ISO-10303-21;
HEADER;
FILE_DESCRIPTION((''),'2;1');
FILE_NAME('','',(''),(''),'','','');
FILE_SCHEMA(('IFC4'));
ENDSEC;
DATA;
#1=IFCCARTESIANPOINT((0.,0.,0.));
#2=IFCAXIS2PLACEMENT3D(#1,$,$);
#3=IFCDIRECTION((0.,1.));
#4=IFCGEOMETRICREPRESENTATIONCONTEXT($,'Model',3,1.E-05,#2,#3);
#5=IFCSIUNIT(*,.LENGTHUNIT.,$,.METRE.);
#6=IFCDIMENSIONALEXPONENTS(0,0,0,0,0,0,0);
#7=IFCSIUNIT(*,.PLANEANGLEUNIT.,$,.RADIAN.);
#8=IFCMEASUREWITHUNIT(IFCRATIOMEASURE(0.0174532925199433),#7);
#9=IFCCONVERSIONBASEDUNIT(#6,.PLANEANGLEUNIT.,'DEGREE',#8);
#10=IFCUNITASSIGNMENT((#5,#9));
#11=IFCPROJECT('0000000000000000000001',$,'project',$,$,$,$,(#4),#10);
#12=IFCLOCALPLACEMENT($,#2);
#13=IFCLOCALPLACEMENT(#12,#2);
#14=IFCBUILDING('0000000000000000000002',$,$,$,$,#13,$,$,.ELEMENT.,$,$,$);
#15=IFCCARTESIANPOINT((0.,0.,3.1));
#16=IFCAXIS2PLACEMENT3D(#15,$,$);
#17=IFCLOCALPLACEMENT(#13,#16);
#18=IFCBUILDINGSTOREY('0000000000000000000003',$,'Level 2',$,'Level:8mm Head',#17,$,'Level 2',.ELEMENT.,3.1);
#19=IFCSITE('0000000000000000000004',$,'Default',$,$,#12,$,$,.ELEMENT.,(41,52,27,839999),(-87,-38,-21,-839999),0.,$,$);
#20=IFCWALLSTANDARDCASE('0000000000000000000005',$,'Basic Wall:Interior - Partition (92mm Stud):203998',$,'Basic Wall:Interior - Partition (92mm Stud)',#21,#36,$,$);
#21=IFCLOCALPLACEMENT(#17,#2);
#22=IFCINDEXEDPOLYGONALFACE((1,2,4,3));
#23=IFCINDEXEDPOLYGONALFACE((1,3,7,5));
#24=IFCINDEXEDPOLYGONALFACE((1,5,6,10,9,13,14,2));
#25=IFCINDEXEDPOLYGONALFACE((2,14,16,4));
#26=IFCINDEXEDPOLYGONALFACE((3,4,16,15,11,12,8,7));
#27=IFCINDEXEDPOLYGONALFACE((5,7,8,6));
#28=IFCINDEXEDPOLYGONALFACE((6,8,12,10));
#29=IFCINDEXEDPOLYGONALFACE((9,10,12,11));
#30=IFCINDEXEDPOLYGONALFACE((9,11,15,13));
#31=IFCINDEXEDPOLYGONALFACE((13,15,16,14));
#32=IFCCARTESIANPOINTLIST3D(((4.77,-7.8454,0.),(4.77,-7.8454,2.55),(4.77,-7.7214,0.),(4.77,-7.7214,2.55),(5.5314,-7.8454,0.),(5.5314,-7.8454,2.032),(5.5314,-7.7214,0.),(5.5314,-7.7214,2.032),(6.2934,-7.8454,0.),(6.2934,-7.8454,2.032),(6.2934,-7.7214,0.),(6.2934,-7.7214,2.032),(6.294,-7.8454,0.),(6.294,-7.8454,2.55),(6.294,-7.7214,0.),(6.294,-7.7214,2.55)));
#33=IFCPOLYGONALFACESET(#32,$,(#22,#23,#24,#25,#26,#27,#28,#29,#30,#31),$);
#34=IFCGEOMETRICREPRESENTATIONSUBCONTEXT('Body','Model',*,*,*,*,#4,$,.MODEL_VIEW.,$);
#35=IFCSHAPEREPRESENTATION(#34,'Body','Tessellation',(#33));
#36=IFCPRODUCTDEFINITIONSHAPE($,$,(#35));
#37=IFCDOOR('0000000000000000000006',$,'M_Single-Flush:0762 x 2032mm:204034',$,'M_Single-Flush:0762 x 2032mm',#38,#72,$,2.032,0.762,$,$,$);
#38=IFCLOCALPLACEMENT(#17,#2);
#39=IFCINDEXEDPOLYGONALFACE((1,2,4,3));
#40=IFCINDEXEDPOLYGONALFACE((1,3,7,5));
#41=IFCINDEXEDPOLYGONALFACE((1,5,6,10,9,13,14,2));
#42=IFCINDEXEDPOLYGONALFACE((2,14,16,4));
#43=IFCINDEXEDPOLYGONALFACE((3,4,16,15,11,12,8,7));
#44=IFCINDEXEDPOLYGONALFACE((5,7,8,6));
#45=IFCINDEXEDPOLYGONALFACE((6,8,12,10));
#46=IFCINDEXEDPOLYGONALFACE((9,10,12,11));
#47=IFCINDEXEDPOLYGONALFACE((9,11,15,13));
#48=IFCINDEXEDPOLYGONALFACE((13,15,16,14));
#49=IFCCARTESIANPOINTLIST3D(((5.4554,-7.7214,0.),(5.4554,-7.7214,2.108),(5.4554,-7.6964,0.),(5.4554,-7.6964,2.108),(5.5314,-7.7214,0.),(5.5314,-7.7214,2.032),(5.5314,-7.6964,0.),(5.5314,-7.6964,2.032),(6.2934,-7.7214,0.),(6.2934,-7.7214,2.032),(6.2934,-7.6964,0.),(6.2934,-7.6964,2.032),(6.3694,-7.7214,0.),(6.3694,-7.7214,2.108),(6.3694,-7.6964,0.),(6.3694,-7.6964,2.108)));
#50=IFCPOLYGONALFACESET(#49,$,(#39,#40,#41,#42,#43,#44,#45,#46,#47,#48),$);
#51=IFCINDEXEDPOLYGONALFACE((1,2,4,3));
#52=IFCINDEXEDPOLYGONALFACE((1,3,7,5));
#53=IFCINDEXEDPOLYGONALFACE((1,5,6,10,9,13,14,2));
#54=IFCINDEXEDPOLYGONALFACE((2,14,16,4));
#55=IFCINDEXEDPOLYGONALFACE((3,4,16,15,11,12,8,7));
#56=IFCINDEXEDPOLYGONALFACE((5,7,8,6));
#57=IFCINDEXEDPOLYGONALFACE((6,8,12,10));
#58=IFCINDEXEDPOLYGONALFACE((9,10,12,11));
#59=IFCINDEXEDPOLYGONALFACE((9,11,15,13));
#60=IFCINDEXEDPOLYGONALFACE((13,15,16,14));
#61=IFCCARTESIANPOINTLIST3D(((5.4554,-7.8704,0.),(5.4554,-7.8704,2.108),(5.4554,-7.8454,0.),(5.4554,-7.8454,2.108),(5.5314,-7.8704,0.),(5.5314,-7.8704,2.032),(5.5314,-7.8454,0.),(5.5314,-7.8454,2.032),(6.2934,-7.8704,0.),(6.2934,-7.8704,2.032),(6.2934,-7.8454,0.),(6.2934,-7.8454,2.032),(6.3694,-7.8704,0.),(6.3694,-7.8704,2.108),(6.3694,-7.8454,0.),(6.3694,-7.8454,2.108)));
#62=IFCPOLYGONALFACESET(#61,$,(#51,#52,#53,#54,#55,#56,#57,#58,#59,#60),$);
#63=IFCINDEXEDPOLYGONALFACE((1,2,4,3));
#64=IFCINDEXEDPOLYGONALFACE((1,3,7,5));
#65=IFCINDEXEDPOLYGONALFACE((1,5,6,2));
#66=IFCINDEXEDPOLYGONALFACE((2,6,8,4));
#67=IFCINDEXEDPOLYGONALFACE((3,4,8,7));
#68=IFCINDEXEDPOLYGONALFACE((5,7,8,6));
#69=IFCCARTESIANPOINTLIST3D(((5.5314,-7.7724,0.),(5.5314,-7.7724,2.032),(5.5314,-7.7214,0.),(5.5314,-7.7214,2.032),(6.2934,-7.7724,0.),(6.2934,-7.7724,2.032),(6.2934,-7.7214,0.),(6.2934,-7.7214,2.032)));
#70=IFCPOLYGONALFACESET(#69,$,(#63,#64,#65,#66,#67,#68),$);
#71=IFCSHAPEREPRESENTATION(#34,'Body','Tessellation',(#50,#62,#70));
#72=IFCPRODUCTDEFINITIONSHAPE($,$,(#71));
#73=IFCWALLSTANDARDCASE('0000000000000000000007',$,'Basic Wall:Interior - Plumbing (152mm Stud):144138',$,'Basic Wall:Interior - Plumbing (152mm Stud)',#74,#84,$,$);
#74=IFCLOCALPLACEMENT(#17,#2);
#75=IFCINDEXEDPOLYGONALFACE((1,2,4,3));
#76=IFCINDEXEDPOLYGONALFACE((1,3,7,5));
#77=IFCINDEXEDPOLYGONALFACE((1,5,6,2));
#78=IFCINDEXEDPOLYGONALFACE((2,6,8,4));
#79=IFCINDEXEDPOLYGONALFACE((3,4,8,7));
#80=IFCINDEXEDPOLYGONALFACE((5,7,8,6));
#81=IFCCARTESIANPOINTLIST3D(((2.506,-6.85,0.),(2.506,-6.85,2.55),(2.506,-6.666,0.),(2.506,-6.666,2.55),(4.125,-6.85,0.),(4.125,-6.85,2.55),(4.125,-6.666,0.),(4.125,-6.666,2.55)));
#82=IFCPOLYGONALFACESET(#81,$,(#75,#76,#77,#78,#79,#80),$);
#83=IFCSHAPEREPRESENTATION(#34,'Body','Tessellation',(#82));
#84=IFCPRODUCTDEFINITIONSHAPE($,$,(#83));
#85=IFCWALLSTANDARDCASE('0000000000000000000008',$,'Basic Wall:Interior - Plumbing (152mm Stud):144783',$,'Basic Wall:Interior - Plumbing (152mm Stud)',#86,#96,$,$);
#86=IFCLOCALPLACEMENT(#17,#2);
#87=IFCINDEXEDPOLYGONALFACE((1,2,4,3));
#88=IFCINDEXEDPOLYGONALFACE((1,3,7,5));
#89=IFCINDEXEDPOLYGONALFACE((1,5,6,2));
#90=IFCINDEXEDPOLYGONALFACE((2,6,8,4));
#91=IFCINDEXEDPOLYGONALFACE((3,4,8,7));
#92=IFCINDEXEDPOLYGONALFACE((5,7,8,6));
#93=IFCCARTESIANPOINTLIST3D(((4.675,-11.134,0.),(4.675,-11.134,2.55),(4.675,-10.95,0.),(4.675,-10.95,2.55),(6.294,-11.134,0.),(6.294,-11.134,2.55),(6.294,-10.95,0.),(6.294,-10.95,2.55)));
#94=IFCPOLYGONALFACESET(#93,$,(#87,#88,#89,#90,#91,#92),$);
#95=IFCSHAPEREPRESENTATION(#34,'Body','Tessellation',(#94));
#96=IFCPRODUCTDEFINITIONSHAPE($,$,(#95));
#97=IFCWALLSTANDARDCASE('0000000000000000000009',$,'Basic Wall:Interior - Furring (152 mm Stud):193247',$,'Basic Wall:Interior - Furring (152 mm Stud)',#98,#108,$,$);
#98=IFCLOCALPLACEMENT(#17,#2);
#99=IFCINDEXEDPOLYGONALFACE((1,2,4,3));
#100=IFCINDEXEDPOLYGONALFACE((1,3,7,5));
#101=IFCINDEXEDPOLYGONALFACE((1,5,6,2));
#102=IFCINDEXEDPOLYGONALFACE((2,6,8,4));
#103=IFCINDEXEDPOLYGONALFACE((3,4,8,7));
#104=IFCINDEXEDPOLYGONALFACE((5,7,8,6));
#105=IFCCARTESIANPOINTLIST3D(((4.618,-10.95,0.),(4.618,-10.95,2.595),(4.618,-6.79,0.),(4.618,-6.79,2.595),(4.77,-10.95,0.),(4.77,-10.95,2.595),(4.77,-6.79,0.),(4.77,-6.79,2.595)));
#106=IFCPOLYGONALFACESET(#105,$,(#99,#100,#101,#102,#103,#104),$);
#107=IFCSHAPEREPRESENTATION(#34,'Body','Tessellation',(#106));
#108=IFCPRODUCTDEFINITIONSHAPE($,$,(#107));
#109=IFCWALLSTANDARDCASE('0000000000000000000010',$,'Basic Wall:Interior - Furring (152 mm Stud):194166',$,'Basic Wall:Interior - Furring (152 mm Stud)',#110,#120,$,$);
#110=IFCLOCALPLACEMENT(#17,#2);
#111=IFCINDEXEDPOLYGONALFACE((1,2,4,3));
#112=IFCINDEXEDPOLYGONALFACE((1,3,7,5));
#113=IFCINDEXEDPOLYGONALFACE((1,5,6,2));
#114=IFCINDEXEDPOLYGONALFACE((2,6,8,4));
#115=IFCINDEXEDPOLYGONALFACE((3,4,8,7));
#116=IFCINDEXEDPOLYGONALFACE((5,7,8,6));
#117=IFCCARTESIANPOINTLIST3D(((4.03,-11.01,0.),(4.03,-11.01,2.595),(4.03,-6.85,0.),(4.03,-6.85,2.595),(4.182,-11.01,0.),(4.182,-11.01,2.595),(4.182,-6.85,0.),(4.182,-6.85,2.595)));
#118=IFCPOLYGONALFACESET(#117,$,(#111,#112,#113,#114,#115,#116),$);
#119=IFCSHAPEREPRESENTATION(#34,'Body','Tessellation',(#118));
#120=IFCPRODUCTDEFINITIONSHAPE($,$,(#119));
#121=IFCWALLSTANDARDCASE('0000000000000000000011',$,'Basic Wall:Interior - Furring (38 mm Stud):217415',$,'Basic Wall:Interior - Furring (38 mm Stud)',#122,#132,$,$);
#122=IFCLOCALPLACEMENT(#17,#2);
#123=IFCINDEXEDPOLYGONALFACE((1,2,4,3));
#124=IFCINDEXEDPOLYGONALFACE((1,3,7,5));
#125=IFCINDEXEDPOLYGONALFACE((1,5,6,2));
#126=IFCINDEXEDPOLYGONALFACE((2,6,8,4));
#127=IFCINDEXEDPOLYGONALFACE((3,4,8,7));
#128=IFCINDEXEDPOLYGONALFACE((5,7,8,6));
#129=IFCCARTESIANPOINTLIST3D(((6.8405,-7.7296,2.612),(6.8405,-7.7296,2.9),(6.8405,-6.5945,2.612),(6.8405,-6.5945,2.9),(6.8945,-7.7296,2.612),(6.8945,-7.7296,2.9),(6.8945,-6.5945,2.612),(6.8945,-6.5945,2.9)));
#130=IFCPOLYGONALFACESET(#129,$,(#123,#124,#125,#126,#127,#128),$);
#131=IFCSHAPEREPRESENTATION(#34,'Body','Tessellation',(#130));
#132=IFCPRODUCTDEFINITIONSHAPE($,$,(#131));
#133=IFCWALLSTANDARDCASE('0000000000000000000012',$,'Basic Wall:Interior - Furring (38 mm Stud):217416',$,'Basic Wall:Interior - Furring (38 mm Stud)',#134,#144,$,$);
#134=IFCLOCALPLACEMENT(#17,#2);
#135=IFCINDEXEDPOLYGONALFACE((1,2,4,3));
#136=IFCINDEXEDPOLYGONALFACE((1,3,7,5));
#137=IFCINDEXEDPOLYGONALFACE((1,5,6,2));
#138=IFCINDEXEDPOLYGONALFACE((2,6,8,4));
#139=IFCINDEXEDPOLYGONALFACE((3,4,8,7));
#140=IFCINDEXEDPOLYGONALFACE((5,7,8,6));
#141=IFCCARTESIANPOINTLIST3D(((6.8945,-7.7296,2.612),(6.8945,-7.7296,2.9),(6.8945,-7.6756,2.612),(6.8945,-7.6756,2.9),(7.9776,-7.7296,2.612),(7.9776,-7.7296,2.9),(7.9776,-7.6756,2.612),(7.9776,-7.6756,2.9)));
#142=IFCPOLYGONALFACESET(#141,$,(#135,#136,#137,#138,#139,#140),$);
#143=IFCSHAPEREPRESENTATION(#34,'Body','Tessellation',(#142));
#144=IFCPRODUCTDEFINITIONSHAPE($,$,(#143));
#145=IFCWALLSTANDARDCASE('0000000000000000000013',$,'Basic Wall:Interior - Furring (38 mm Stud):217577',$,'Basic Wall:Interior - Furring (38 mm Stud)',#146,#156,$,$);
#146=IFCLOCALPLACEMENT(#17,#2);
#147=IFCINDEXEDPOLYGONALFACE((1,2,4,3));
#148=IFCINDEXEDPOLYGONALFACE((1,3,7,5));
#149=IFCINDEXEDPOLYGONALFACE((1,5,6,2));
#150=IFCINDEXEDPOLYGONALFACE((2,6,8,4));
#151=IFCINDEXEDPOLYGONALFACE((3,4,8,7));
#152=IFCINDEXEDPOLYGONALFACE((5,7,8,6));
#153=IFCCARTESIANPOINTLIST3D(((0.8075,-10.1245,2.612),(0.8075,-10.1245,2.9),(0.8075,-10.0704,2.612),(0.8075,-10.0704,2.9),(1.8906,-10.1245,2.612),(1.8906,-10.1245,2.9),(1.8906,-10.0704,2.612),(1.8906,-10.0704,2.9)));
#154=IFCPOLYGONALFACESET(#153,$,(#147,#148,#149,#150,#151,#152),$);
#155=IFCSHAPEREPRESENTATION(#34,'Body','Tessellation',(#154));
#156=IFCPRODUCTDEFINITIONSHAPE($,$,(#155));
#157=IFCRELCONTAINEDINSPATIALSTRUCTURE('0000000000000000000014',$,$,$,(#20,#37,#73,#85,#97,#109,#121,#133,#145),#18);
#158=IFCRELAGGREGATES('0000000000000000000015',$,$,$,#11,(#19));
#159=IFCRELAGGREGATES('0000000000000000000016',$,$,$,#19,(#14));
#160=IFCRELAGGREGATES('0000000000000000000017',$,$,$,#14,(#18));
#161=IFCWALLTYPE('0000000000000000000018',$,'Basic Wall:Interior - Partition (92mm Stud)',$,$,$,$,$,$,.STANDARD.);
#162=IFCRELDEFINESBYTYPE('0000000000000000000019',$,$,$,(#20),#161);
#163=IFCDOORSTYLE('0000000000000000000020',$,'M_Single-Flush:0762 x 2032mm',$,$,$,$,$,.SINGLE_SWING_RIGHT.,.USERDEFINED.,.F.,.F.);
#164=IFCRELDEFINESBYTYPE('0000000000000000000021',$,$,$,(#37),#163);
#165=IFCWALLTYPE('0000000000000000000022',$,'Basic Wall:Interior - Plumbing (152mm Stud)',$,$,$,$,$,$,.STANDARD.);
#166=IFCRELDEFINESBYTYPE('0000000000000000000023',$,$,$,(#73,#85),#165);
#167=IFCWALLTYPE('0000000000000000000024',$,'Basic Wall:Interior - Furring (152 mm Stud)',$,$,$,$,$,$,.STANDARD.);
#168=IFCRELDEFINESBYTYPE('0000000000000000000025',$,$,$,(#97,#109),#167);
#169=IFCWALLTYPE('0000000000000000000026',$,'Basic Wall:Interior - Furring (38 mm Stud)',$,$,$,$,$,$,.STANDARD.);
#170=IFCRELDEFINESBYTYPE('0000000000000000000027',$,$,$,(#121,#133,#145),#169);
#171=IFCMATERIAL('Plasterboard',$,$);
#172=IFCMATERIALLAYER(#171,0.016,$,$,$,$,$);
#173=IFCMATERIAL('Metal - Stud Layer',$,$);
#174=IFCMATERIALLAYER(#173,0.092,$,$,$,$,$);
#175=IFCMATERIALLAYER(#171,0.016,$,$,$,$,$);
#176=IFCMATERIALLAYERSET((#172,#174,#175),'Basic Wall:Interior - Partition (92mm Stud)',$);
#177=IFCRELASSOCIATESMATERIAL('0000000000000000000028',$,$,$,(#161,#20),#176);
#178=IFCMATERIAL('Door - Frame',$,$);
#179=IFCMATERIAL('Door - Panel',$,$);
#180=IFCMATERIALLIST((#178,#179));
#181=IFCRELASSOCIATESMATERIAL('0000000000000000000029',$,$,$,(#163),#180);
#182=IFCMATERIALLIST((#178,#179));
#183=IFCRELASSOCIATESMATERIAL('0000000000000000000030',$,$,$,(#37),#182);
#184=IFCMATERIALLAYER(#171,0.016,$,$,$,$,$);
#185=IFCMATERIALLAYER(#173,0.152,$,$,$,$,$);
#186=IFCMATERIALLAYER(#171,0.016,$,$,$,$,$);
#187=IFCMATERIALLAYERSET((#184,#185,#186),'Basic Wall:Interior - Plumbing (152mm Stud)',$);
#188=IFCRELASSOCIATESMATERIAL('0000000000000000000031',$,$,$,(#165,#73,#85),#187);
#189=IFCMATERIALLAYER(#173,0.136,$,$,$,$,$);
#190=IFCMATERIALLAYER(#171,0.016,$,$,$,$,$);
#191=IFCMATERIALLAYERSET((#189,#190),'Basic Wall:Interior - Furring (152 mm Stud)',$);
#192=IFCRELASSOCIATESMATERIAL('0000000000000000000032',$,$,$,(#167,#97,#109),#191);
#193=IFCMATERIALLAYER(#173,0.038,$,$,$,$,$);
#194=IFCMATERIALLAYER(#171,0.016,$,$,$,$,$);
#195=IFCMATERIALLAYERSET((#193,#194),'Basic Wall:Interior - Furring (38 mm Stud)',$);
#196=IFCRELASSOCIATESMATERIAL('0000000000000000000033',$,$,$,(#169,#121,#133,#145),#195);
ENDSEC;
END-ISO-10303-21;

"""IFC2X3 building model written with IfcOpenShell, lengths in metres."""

from ifc_helpers import new_model, entity, si_unit, converted_unit, direction, frame, frame_2d, origin, origin_2d_with_axis, place, context, subcontext, project, spatial, polyline, rectangle, outline, extrude, source, transform, mapped, material, material_list, layer, layer_set, layer_usage, type_object, type_shapes, element, fill, save


model = new_model("IFC2X3")

# Units and contexts
model_context = context("Model", 3, precision=1e-05, world=origin(), true_north=direction((0.0, 1.0)))
body_context = subcontext(model_context, "Body", "Model", "MODEL_VIEW")
ifc_project = project(units=[si_unit("LENGTHUNIT", "METRE"), converted_unit("PLANEANGLEUNIT", "DEGREE", entity("IfcRatioMeasure", 0.0174532925199433), si_unit("PLANEANGLEUNIT", "RADIAN"), dimensions=[0, 0, 0, 0, 0, 0, 0])], contexts=[model_context])

# Site, building, storey
site_placement = place(None, origin())
site = spatial("IfcSite", under=ifc_project, at=site_placement, Name="Default", CompositionType="ELEMENT", RefLatitude=(41, 52, 27, 839999), RefLongitude=(-87, -38, -21, -839999), RefElevation=0.0)
building_placement = place(site_placement, origin())
building = spatial("IfcBuilding", under=site, at=building_placement, CompositionType="ELEMENT")
storey_placement = place(building_placement, frame((0.0, 0.0, 3.1)))
storey = spatial("IfcBuildingStorey", under=building, at=storey_placement, Name="Level 2", ObjectType="Level:8mm Head", LongName="Level 2", CompositionType="ELEMENT", Elevation=3.1)

# Shared definitions
ifc_material_1 = material(Name="Plasterboard")
ifc_layer_1 = layer(ifc_material_1, 0.016)
ifc_material_2 = material(Name="Metal - Stud Layer")
ifc_layer_2 = layer(ifc_material_2, 0.092)
ifc_layer_3 = layer(ifc_material_1, 0.016)
ifc_layer_set_1 = layer_set([ifc_layer_1, ifc_layer_2, ifc_layer_3], Name="Basic Wall:Interior - Partition (92mm Stud)")
wall_type_1 = type_object("IfcWallType", Name="Basic Wall:Interior - Partition (92mm Stud)", PredefinedType="STANDARD", material=ifc_layer_set_1)

# Wall, opening, door
ifc_material_3 = material(Name="Door - Frame")
ifc_material_4 = material(Name="Door - Panel")
ifc_material_list_1 = material_list([ifc_material_3, ifc_material_4])
door_style = type_object("IfcDoorStyle", Name="M_Single-Flush:0762 x 2032mm", ConstructionType="USERDEFINED", OperationType="SINGLE_SWING_RIGHT", ParameterTakesPrecedence=False, Sizeable=False, material=ifc_material_list_1)
shared_shape_1 = source(origin(), body_context, "Body", "SweptSolid", [
    extrude(outline(polyline([(-0.457, -1.073), (0.457, -1.073), (0.457, 1.035), (0.381, 1.035), (0.381, -0.997), (-0.381, -0.997), (-0.381, 1.035), (-0.457, 1.035), (-0.457, -1.073)])), frame((0.381, 0.124, 1.035), z_axis=(0.0, 1.0, 0.0), x_axis=(1.0, 0.0, 0.0)), (0.0, 0.0, 1.0), 0.025),
    extrude(outline(polyline([(-1.073, -0.457), (1.035, -0.457), (1.035, -0.381), (-0.997, -0.381), (-0.997, 0.381), (1.035, 0.381), (1.035, 0.457), (-1.073, 0.457), (-1.073, -0.457)])), frame((0.381, -0.025, 1.035), z_axis=(0.0, 1.0, 0.0), x_axis=(0.0, 0.0, -1.0)), (0.0, 0.0, 1.0), 0.025),
    extrude(rectangle(XDim=0.051, YDim=0.762, at=origin_2d_with_axis()), frame((0.381, 0.0985, 0.0), z_axis=(0.0, 0.0, 1.0), x_axis=(0.0, 1.0, 0.0)), (0.0, 0.0, 1.0), 2.032),
])
type_shapes(door_style, [shared_shape_1])
ifc_layer_usage_1 = layer_usage(ifc_layer_set_1, "AXIS2", "POSITIVE", -0.062)
wall_1_placement = place(storey_placement, frame((4.77, -7.7834, 0.0)))
wall_1 = element("IfcWallStandardCase", 1, at=wall_1_placement, inside=storey, type_object=wall_type_1, material=ifc_layer_usage_1, Name="Basic Wall:Interior - Partition (92mm Stud):203998", ObjectType="Basic Wall:Interior - Partition (92mm Stud)", context=body_context, shape_type="SweptSolid", body=[
    extrude(rectangle(XDim=1.524, YDim=0.124, at=frame_2d((0.762, 0.0), x_axis=(-1.0, 0.0))), origin(), (0.0, 0.0, 1.0), 2.55),
])
opening_1_placement = place(wall_1_placement, frame((0.7614, -0.062, 0.0)))
opening_1 = element("IfcOpeningElement", 2, at=opening_1_placement, cuts=wall_1, ObjectType="Opening", context=body_context, shape_type="SweptSolid", body=[
    extrude(rectangle(XDim=0.762, YDim=2.032, at=frame_2d((1.016, 0.381), x_axis=(0.0, 1.0))), frame((0.0, 0.0, 0.0), z_axis=(0.0, 1.0, 0.0), x_axis=(0.0, 0.0, 1.0)), (0.0, 0.0, 1.0), 0.124),
])
ifc_material_list_2 = material_list([ifc_material_3, ifc_material_4])
door_1_placement = place(opening_1_placement, origin())
door_1 = element("IfcDoor", 3, at=door_1_placement, inside=storey, type_object=door_style, material=ifc_material_list_2, Name="M_Single-Flush:0762 x 2032mm:204034", ObjectType="M_Single-Flush:0762 x 2032mm", OverallHeight=2.032, OverallWidth=0.762, context=body_context, shape_type="MappedRepresentation", body=[
    mapped(shared_shape_1, transform((0.0, 0.0, 0.0), scale=1.0)),
])
fill(opening_1, door_1)

# Walls
ifc_layer_4 = layer(ifc_material_1, 0.016)
ifc_layer_5 = layer(ifc_material_2, 0.152)
ifc_layer_6 = layer(ifc_material_1, 0.016)
ifc_layer_set_2 = layer_set([ifc_layer_4, ifc_layer_5, ifc_layer_6], Name="Basic Wall:Interior - Plumbing (152mm Stud)")
ifc_layer_usage_2 = layer_usage(ifc_layer_set_2, "AXIS2", "NEGATIVE", 0.092)
wall_type_2 = type_object("IfcWallType", Name="Basic Wall:Interior - Plumbing (152mm Stud)", PredefinedType="STANDARD", material=ifc_layer_set_2)
wall_2_placement = place(storey_placement, frame((2.506, -6.758, 0.0)))
element("IfcWallStandardCase", 4, at=wall_2_placement, inside=storey, type_object=wall_type_2, material=ifc_layer_usage_2, Name="Basic Wall:Interior - Plumbing (152mm Stud):144138", ObjectType="Basic Wall:Interior - Plumbing (152mm Stud)", context=body_context, shape_type="SweptSolid", body=[
    extrude(rectangle(XDim=1.619, YDim=0.184, at=frame_2d((0.8095, 0.0), x_axis=(-1.0, 0.0))), origin(), (0.0, 0.0, 1.0), 2.55),
])
ifc_layer_usage_3 = layer_usage(ifc_layer_set_2, "AXIS2", "NEGATIVE", 0.092)
wall_3_placement = place(storey_placement, frame((6.294, -11.042, 0.0), z_axis=(0.0, 0.0, 1.0), x_axis=(-1.0, 0.0, 0.0)))
element("IfcWallStandardCase", 5, at=wall_3_placement, inside=storey, type_object=wall_type_2, material=ifc_layer_usage_3, Name="Basic Wall:Interior - Plumbing (152mm Stud):144783", ObjectType="Basic Wall:Interior - Plumbing (152mm Stud)", context=body_context, shape_type="SweptSolid", body=[
    extrude(rectangle(XDim=1.619, YDim=0.184, at=frame_2d((0.8095, 0.0), x_axis=(-1.0, 0.0))), origin(), (0.0, 0.0, 1.0), 2.55),
])
ifc_layer_7 = layer(ifc_material_2, 0.136)
ifc_layer_8 = layer(ifc_material_1, 0.016)
ifc_layer_set_3 = layer_set([ifc_layer_7, ifc_layer_8], Name="Basic Wall:Interior - Furring (152 mm Stud)")
ifc_layer_usage_4 = layer_usage(ifc_layer_set_3, "AXIS2", "POSITIVE", -0.076)
wall_type_3 = type_object("IfcWallType", Name="Basic Wall:Interior - Furring (152 mm Stud)", PredefinedType="STANDARD", material=ifc_layer_set_3)
wall_4_placement = place(storey_placement, frame((4.694, -6.79, 0.0), z_axis=(0.0, 0.0, 1.0), x_axis=(0.0, -1.0, 0.0)))
element("IfcWallStandardCase", 6, at=wall_4_placement, inside=storey, type_object=wall_type_3, material=ifc_layer_usage_4, Name="Basic Wall:Interior - Furring (152 mm Stud):193247", ObjectType="Basic Wall:Interior - Furring (152 mm Stud)", context=body_context, shape_type="SweptSolid", body=[
    extrude(rectangle(XDim=4.16, YDim=0.152, at=frame_2d((2.08, 0.0), x_axis=(-1.0, 0.0))), origin(), (0.0, 0.0, 1.0), 2.595),
])
ifc_layer_usage_5 = layer_usage(ifc_layer_set_3, "AXIS2", "POSITIVE", -0.076)
wall_5_placement = place(storey_placement, frame((4.106, -11.01, 0.0), z_axis=(0.0, 0.0, 1.0), x_axis=(0.0, 1.0, 0.0)))
element("IfcWallStandardCase", 7, at=wall_5_placement, inside=storey, type_object=wall_type_3, material=ifc_layer_usage_5, Name="Basic Wall:Interior - Furring (152 mm Stud):194166", ObjectType="Basic Wall:Interior - Furring (152 mm Stud)", context=body_context, shape_type="SweptSolid", body=[
    extrude(rectangle(XDim=4.16, YDim=0.152, at=frame_2d((2.08, 0.0), x_axis=(-1.0, 0.0))), origin(), (0.0, 0.0, 1.0), 2.595),
])
ifc_layer_9 = layer(ifc_material_2, 0.038)
ifc_layer_10 = layer(ifc_material_1, 0.016)
ifc_layer_set_4 = layer_set([ifc_layer_9, ifc_layer_10], Name="Basic Wall:Interior - Furring (38 mm Stud)")
ifc_layer_usage_6 = layer_usage(ifc_layer_set_4, "AXIS2", "NEGATIVE", 0.027)
wall_type_4 = type_object("IfcWallType", Name="Basic Wall:Interior - Furring (38 mm Stud)", PredefinedType="STANDARD", material=ifc_layer_set_4)
wall_6_placement = place(storey_placement, frame((6.8675, -7.7296, 2.612), z_axis=(0.0, 0.0, 1.0), x_axis=(0.0, 1.0, 0.0)))
element("IfcWallStandardCase", 8, at=wall_6_placement, inside=storey, type_object=wall_type_4, material=ifc_layer_usage_6, Name="Basic Wall:Interior - Furring (38 mm Stud):217415", ObjectType="Basic Wall:Interior - Furring (38 mm Stud)", context=body_context, shape_type="SweptSolid", body=[
    extrude(rectangle(XDim=1.1351, YDim=0.054, at=frame_2d((0.5675, 0.0), x_axis=(-1.0, 0.0))), origin(), (0.0, 0.0, 1.0), 0.288),
])
ifc_layer_usage_7 = layer_usage(ifc_layer_set_4, "AXIS2", "NEGATIVE", 0.027)
wall_7_placement = place(storey_placement, frame((7.9776, -7.7026, 2.612), z_axis=(0.0, 0.0, 1.0), x_axis=(-1.0, 0.0, 0.0)))
element("IfcWallStandardCase", 9, at=wall_7_placement, inside=storey, type_object=wall_type_4, material=ifc_layer_usage_7, Name="Basic Wall:Interior - Furring (38 mm Stud):217416", ObjectType="Basic Wall:Interior - Furring (38 mm Stud)", context=body_context, shape_type="SweptSolid", body=[
    extrude(rectangle(XDim=1.0831, YDim=0.054, at=frame_2d((0.5415, 0.0), x_axis=(-1.0, 0.0))), origin(), (0.0, 0.0, 1.0), 0.288),
])
ifc_layer_usage_8 = layer_usage(ifc_layer_set_4, "AXIS2", "NEGATIVE", 0.027)
wall_8_placement = place(storey_placement, frame((0.8075, -10.0975, 2.612)))
element("IfcWallStandardCase", 10, at=wall_8_placement, inside=storey, type_object=wall_type_4, material=ifc_layer_usage_8, Name="Basic Wall:Interior - Furring (38 mm Stud):217577", ObjectType="Basic Wall:Interior - Furring (38 mm Stud)", context=body_context, shape_type="SweptSolid", body=[
    extrude(rectangle(XDim=1.0831, YDim=0.054, at=frame_2d((0.5415, 0.0), x_axis=(-1.0, 0.0))), origin(), (0.0, 0.0, 1.0), 0.288),
])

save(model, "model.ifc")
